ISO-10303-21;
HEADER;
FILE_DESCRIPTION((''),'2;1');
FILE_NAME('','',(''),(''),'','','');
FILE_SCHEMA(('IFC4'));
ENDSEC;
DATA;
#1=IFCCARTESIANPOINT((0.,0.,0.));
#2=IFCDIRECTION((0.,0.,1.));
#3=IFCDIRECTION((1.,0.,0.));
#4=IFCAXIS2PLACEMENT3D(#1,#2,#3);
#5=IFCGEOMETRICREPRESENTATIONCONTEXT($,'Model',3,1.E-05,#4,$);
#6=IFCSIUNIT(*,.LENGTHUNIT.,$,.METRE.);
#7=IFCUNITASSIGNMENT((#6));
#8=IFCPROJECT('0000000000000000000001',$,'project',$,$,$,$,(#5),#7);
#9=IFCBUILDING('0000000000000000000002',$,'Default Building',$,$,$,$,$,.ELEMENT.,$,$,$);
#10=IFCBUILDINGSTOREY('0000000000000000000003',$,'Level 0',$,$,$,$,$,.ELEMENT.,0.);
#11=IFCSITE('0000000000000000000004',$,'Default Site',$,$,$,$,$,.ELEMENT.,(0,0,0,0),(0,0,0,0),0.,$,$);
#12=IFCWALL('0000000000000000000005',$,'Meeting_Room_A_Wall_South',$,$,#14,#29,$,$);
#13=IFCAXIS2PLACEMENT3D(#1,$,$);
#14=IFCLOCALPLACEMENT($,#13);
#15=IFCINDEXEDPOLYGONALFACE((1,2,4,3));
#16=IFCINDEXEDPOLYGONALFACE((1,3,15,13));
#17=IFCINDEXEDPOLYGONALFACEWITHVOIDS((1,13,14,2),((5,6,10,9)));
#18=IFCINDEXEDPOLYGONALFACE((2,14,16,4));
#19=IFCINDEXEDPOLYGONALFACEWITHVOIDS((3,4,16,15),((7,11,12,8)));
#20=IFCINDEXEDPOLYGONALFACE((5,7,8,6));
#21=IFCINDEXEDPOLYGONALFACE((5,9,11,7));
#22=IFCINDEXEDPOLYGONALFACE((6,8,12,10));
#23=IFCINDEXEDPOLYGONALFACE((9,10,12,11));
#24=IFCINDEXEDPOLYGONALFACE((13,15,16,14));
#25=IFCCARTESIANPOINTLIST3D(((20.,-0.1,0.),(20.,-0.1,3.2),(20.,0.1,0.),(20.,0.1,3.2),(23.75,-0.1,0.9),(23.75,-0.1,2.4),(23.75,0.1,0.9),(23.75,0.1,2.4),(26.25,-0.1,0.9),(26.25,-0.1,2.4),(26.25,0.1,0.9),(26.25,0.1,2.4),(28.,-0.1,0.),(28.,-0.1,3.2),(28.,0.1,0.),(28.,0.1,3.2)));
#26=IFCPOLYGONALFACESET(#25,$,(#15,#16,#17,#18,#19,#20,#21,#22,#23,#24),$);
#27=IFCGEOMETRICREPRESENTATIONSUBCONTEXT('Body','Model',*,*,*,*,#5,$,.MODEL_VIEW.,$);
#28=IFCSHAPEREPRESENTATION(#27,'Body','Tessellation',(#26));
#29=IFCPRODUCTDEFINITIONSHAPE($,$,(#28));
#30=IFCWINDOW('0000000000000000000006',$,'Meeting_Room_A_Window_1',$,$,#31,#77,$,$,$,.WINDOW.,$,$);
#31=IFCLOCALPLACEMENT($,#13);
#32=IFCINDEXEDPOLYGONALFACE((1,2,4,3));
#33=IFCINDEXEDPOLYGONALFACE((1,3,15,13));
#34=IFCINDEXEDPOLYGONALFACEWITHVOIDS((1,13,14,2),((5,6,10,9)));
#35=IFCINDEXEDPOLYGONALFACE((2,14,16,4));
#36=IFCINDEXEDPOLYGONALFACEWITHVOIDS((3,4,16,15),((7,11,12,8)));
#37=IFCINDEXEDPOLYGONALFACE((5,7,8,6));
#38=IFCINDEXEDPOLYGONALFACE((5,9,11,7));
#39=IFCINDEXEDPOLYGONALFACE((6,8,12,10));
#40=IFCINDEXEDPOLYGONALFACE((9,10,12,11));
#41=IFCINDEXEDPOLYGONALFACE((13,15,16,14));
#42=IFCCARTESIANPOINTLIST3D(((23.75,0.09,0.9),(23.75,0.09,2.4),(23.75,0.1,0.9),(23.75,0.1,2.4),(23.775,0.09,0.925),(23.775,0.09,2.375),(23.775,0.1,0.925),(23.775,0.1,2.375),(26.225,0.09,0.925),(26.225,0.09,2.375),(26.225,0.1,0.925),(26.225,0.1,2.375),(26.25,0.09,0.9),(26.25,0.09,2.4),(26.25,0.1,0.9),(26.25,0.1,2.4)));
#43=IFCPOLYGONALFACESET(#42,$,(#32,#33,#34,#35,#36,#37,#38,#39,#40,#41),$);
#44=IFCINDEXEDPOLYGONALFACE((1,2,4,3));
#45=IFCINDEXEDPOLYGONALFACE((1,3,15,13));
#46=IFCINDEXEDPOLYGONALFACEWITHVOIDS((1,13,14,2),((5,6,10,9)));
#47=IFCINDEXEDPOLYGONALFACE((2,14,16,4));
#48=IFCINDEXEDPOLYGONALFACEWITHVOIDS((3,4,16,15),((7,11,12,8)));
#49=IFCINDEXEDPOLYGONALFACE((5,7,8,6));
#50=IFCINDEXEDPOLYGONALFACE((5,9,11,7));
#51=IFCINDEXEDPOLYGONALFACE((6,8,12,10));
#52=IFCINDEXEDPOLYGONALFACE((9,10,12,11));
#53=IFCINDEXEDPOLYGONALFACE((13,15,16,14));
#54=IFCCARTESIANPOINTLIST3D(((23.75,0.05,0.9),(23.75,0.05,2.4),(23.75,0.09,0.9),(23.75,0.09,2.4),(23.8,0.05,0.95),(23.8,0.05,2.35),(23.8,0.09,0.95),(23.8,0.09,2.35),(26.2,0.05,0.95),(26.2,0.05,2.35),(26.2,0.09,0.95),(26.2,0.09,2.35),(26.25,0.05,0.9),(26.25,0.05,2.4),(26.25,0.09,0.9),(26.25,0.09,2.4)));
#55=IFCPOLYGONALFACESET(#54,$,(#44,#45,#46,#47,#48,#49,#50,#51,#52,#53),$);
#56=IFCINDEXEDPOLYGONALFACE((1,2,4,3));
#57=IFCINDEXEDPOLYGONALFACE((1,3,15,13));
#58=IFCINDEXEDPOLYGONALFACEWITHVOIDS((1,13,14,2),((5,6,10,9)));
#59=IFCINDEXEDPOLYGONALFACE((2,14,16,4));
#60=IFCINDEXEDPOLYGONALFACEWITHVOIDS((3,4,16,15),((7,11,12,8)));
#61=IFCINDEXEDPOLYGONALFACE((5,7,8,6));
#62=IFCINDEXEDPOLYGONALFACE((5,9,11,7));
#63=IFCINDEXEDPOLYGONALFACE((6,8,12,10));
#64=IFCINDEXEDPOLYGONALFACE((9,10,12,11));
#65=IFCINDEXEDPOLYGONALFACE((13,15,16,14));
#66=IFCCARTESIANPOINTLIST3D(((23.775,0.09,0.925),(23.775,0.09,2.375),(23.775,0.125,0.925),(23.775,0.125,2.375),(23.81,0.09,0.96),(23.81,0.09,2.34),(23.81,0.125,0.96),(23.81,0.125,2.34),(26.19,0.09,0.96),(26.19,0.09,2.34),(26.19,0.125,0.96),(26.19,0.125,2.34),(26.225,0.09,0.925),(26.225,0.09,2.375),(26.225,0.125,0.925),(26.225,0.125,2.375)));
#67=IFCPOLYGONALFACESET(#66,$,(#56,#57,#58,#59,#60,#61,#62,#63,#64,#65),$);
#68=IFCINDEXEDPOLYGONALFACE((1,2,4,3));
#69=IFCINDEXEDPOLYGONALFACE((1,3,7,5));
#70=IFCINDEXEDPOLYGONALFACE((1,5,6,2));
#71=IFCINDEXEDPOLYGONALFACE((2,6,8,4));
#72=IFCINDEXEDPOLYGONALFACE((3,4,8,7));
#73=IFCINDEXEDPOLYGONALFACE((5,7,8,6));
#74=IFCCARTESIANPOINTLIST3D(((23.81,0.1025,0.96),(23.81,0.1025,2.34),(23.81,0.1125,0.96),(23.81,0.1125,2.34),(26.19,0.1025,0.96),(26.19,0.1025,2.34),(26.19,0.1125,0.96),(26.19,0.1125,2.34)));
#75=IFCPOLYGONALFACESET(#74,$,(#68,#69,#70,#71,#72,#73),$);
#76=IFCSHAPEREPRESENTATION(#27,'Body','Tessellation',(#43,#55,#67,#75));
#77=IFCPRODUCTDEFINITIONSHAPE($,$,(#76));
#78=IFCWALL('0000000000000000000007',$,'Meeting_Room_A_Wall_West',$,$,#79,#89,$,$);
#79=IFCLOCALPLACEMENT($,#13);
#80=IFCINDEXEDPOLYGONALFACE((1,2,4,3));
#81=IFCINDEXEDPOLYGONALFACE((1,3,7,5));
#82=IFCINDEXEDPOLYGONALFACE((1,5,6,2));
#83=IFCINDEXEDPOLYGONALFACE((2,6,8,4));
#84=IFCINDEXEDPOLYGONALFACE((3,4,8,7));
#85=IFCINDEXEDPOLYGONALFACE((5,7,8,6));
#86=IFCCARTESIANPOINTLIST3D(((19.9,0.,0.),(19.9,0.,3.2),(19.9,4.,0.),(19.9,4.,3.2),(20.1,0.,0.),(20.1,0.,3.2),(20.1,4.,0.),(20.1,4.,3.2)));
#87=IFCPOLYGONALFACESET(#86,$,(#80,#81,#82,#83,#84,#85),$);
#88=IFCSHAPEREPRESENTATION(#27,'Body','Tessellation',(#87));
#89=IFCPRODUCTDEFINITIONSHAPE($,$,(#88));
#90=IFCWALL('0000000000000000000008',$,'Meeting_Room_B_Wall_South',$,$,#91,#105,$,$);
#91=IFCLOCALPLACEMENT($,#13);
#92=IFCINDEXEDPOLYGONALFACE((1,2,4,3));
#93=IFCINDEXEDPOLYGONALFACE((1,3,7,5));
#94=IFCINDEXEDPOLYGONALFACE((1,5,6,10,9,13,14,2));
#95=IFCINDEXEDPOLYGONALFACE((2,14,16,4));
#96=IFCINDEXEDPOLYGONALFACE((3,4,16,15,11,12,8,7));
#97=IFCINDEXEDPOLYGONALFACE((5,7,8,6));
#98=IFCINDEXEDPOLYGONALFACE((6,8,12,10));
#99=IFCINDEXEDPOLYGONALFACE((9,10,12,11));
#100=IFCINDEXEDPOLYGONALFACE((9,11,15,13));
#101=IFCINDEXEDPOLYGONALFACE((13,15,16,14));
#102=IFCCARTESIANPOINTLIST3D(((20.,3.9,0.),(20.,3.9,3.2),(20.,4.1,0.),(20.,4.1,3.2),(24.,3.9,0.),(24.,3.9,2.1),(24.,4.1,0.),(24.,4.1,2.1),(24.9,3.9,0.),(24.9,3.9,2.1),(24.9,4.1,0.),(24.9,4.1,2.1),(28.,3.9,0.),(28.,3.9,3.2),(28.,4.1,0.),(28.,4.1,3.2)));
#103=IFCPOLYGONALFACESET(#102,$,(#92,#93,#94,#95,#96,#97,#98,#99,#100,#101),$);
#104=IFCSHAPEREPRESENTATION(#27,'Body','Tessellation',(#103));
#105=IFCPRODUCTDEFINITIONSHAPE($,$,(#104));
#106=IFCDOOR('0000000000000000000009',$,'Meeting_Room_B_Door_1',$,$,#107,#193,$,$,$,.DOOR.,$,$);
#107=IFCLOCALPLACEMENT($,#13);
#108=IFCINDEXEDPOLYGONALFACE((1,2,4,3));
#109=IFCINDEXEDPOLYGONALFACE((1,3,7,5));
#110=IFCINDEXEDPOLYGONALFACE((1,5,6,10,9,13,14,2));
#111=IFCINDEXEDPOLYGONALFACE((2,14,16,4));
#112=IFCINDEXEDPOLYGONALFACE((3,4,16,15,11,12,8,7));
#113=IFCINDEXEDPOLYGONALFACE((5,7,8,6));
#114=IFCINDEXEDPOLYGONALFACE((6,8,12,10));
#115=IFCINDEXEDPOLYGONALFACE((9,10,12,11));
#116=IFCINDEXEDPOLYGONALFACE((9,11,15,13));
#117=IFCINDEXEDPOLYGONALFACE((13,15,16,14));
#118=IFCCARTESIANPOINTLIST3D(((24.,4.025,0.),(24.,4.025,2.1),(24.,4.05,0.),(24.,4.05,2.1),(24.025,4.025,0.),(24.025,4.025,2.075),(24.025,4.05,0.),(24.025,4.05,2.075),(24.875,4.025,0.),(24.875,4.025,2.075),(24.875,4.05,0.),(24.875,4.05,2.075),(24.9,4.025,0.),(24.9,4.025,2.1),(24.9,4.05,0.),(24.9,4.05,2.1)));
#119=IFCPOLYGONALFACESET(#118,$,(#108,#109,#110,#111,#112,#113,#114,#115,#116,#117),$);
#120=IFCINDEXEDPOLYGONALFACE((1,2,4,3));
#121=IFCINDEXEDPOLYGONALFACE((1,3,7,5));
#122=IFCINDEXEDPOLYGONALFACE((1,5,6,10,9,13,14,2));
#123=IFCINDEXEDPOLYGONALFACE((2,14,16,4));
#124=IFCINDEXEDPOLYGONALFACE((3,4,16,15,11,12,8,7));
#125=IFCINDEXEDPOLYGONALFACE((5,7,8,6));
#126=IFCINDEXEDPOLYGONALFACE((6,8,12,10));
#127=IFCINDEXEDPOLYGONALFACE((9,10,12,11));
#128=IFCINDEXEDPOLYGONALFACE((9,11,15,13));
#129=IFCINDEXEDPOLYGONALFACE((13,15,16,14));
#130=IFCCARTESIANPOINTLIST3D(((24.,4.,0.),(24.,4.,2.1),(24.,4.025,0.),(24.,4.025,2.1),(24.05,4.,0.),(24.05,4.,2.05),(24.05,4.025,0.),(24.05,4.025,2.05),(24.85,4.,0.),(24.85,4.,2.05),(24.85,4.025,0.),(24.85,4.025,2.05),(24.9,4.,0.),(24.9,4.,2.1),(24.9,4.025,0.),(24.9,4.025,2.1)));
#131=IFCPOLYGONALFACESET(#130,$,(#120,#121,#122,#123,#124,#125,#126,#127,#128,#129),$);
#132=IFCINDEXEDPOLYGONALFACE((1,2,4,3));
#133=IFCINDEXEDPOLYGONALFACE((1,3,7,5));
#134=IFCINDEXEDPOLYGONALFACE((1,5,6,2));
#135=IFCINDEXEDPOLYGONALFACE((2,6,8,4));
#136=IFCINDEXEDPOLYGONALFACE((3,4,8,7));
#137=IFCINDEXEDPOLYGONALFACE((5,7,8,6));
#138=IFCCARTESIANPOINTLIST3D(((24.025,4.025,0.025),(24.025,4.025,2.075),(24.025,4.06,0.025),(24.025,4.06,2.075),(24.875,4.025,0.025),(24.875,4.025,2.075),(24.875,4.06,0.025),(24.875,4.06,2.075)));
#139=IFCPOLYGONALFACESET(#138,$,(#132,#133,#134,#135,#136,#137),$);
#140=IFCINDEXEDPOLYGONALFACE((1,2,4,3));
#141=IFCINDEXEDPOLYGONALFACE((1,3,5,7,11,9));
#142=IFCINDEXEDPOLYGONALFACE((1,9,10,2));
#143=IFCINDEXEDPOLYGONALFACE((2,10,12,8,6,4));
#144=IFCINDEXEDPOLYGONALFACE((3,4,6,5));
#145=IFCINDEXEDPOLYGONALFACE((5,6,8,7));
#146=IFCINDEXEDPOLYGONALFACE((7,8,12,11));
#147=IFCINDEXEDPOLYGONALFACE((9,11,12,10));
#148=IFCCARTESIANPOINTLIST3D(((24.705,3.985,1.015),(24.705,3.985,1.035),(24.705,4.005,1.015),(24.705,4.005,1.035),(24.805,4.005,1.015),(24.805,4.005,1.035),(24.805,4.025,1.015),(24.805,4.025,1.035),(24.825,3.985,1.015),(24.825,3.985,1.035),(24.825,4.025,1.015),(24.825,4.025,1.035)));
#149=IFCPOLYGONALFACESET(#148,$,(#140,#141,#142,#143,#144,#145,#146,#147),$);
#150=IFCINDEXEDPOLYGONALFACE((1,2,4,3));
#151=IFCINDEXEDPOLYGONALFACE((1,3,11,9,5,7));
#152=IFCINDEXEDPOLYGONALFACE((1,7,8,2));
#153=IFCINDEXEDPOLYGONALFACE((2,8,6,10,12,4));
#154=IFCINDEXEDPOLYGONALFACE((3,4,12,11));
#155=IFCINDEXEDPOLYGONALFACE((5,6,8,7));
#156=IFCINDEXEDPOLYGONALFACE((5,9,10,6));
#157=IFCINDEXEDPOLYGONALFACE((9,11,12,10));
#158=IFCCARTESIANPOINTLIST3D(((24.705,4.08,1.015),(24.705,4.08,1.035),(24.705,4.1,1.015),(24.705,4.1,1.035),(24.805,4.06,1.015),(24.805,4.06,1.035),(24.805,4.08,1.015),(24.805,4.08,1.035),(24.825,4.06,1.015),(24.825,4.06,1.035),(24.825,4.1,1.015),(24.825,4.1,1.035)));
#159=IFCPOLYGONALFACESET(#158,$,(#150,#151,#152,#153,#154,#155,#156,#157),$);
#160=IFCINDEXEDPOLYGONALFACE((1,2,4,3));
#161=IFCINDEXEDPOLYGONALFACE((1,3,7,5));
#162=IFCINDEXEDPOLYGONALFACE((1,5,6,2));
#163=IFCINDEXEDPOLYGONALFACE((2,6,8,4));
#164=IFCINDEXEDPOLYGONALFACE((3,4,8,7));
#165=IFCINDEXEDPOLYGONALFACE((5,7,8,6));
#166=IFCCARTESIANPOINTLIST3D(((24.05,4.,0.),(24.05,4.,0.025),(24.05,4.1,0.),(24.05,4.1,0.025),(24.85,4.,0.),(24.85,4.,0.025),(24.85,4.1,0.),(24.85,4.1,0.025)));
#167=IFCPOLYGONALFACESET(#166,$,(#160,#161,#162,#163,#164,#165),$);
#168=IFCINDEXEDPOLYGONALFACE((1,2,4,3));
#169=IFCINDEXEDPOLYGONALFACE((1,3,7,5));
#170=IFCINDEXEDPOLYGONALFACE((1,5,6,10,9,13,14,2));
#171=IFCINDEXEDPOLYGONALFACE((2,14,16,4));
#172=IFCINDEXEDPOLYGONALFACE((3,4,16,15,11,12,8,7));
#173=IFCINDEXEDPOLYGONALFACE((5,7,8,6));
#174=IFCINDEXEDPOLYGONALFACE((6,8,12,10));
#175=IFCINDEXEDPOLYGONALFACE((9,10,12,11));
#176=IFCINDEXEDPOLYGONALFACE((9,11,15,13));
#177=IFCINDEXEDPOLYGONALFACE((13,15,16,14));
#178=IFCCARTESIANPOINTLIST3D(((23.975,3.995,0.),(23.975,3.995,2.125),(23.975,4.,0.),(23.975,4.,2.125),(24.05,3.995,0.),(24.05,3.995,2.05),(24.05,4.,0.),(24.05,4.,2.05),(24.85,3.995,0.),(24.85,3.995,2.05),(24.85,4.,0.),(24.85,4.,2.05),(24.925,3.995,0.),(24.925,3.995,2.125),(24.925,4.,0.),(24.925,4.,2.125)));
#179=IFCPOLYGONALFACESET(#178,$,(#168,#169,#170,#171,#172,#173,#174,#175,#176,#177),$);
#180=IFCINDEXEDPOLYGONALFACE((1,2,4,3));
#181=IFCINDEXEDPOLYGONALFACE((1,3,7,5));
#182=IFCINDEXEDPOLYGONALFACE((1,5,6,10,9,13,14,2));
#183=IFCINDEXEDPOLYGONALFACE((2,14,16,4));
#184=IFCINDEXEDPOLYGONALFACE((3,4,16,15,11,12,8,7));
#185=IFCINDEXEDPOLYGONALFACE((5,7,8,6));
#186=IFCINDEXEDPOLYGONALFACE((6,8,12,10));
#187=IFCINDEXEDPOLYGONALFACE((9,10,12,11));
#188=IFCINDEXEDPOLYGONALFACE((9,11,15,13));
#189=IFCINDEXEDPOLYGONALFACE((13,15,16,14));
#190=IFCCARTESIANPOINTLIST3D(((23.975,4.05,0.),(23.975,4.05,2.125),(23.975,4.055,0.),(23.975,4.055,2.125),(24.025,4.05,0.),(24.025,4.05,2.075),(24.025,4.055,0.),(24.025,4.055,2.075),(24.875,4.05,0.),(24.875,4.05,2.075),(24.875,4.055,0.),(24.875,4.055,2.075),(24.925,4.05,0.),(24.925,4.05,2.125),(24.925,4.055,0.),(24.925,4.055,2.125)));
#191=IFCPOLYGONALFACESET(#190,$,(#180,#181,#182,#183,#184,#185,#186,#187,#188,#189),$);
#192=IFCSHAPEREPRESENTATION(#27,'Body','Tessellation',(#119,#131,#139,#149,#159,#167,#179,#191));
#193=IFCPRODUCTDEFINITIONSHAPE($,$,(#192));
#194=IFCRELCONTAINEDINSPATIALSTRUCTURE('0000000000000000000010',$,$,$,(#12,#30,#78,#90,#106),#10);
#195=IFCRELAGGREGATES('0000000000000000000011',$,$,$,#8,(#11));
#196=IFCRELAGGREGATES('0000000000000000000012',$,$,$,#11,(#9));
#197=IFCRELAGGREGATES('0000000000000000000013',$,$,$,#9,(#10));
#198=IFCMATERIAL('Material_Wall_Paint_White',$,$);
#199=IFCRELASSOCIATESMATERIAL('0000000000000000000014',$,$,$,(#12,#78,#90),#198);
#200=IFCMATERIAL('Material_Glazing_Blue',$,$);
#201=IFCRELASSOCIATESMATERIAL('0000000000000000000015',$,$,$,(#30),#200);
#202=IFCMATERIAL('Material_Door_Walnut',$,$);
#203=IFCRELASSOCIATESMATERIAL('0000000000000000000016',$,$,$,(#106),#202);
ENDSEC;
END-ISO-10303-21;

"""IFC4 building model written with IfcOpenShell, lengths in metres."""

from ifc_helpers import new_model, si_unit, frame, origin_with_axes, place, context, subcontext, project, spatial, line, indexed_curve, outline, extrude, material, element, fill, save


model = new_model("IFC4")

# Units and contexts
model_context = context("Model", 3, precision=1e-05, world=origin_with_axes())
body_context = subcontext(model_context, "Body", "Model", "MODEL_VIEW")
ifc_project = project(units=[si_unit("LENGTHUNIT", "METRE")], contexts=[model_context])

# Site, building, storey
site = spatial("IfcSite", under=ifc_project, Name="Default Site", CompositionType="ELEMENT", RefLatitude=(0, 0, 0, 0), RefLongitude=(0, 0, 0, 0), RefElevation=0.0)
building = spatial("IfcBuilding", under=site, Name="Default Building", CompositionType="ELEMENT")
storey = spatial("IfcBuildingStorey", under=building, Name="Level 0", CompositionType="ELEMENT", Elevation=0.0)

# Shared definitions
ifc_material_1 = material(Name="Material_Wall_Paint_White")

# Shared definitions
ifc_material_2 = material(Name="Material_Door_Walnut")

# Wall, opening, window
wall_1_placement = place(None, frame((20.0, 0.0, 0.0), z_axis=(0.0, 0.0, 1.0), x_axis=(1.0, 0.0, 0.0)))
wall_1 = element("IfcWall", 1, at=wall_1_placement, inside=storey, material=ifc_material_1, Name="Meeting_Room_A_Wall_South", context=body_context, shape_type="SweptSolid", body=[
    extrude(outline(indexed_curve([(0.0, 0.0), (0.0, 0.2), (8.0, 0.2), (8.0, 0.0), (0.0, 0.0)], self_intersect=False)), frame((0.0, -0.1, 0.0), z_axis=(0.0, 0.0, 1.0), x_axis=(1.0, 0.0, 0.0)), (0.0, 0.0, 1.0), 3.2),
])
opening_1_placement = place(wall_1_placement, frame((3.75, -0.5, 0.9), z_axis=(0.0, 0.0, 1.0), x_axis=(1.0, 0.0, 0.0)))
opening_1 = element("IfcOpeningElement", 2, at=opening_1_placement, inside=storey, cuts=wall_1, PredefinedType="OPENING", context=body_context, shape_type="SweptSolid", body=[
    extrude(outline(indexed_curve([(0.0, 0.0), (0.0, 1.0), (2.5, 1.0), (2.5, 0.0), (0.0, 0.0)], self_intersect=False)), origin_with_axes(), (0.0, 0.0, 1.0), 1.5),
])
ifc_material_3 = material(Name="Material_Glazing_Blue")
window_placement = place(None, frame((23.75, 0.0, 0.9), z_axis=(0.0, 0.0, 1.0), x_axis=(1.0, 0.0, 0.0)))
window = element("IfcWindow", 3, at=window_placement, inside=storey, material=ifc_material_3, Name="Meeting_Room_A_Window_1", PredefinedType="WINDOW", context=body_context, shape_type="SweptSolid", body=[
    extrude(outline(indexed_curve([(0.0, 0.0), (2.5, 0.0), (2.5, 1.5), (0.0, 1.5)], segments=[line(1, 2, 3, 4, 1)]), holes=[indexed_curve([(0.025, 0.025), (2.475, 0.025), (2.475, 1.475), (0.025, 1.475)], segments=[line(1, 2, 3, 4, 1)])]), frame((0.0, 0.09, 0.0), z_axis=(0.0, -1.0, 0.0), x_axis=(1.0, 0.0, 0.0)), (0.0, 0.0, -1.0), 0.01),
    extrude(outline(indexed_curve([(0.0, 0.0), (2.5, 0.0), (2.5, 1.5), (0.0, 1.5)], segments=[line(1, 2, 3, 4, 1)]), holes=[indexed_curve([(0.05, 0.05), (2.45, 0.05), (2.45, 1.45), (0.05, 1.45)], segments=[line(1, 2, 3, 4, 1)])]), frame((0.0, 0.05, 0.0), z_axis=(0.0, -1.0, 0.0), x_axis=(1.0, 0.0, 0.0)), (0.0, 0.0, -1.0), 0.04),
    extrude(outline(indexed_curve([(0.0, 0.0), (2.45, 0.0), (2.45, 1.45), (0.0, 1.45)], segments=[line(1, 2, 3, 4, 1)]), holes=[indexed_curve([(0.035, 0.035), (2.415, 0.035), (2.415, 1.415), (0.035, 1.415)], segments=[line(1, 2, 3, 4, 1)])]), frame((0.025, 0.09, 0.025), z_axis=(0.0, -1.0, 0.0), x_axis=(1.0, 0.0, 0.0)), (0.0, 0.0, -1.0), 0.035),
    extrude(outline(indexed_curve([(0.035, 0.035), (2.415, 0.035), (2.415, 1.415), (0.035, 1.415)], segments=[line(1, 2, 3, 4, 1)])), frame((0.025, 0.1025, 0.025), z_axis=(0.0, -1.0, 0.0), x_axis=(1.0, 0.0, 0.0)), (0.0, 0.0, -1.0), 0.01),
])
fill(opening_1, window)

# Wall
wall_2_placement = place(None, frame((20.0, 4.0, 0.0), z_axis=(0.0, 0.0, 1.0), x_axis=(0.0, -1.0, 0.0)))
element("IfcWall", 4, at=wall_2_placement, inside=storey, material=ifc_material_1, Name="Meeting_Room_A_Wall_West", context=body_context, shape_type="SweptSolid", body=[
    extrude(outline(indexed_curve([(0.0, 0.0), (0.0, 0.2), (4.0, 0.2), (4.0, 0.0), (0.0, 0.0)], self_intersect=False)), frame((0.0, -0.1, 0.0), z_axis=(0.0, 0.0, 1.0), x_axis=(1.0, 0.0, 0.0)), (0.0, 0.0, 1.0), 3.2),
])

# Wall, opening, door
wall_3_placement = place(None, frame((20.0, 4.0, 0.0), z_axis=(0.0, 0.0, 1.0), x_axis=(1.0, 0.0, 0.0)))
wall_3 = element("IfcWall", 5, at=wall_3_placement, inside=storey, material=ifc_material_1, Name="Meeting_Room_B_Wall_South", context=body_context, shape_type="SweptSolid", body=[
    extrude(outline(indexed_curve([(0.0, 0.0), (0.0, 0.2), (8.0, 0.2), (8.0, 0.0), (0.0, 0.0)], self_intersect=False)), frame((0.0, -0.1, 0.0), z_axis=(0.0, 0.0, 1.0), x_axis=(1.0, 0.0, 0.0)), (0.0, 0.0, 1.0), 3.2),
])
opening_2_placement = place(wall_3_placement, frame((4.0, -0.5, 0.0), z_axis=(0.0, 0.0, 1.0), x_axis=(1.0, 0.0, 0.0)))
opening_2 = element("IfcOpeningElement", 6, at=opening_2_placement, inside=storey, cuts=wall_3, PredefinedType="OPENING", context=body_context, shape_type="SweptSolid", body=[
    extrude(outline(indexed_curve([(0.0, 0.0), (0.0, 1.0), (0.9, 1.0), (0.9, 0.0), (0.0, 0.0)], self_intersect=False)), origin_with_axes(), (0.0, 0.0, 1.0), 2.1),
])
door_1_placement = place(None, frame((24.0, 4.0, 0.0), z_axis=(0.0, 0.0, 1.0), x_axis=(1.0, 0.0, 0.0)))
door_1 = element("IfcDoor", 7, at=door_1_placement, inside=storey, material=ifc_material_2, Name="Meeting_Room_B_Door_1", PredefinedType="DOOR", context=body_context, shape_type="SweptSolid", body=[
    extrude(outline(indexed_curve([(0.0, 0.0), (0.0, 2.1), (0.9, 2.1), (0.9, 0.0), (0.875, 0.0), (0.875, 2.075), (0.025, 2.075), (0.025, 0.0)], segments=[line(1, 2, 3, 4, 5, 6, 7, 8, 1)])), frame((0.0, 0.025, 0.0), z_axis=(0.0, -1.0, 0.0), x_axis=(1.0, 0.0, 0.0)), (0.0, 0.0, -1.0), 0.025),
    extrude(outline(indexed_curve([(0.0, 0.0), (0.0, 2.1), (0.9, 2.1), (0.9, 0.0), (0.85, 0.0), (0.85, 2.05), (0.05, 2.05), (0.05, 0.0)], segments=[line(1, 2, 3, 4, 5, 6, 7, 8, 1)])), frame((0.0, 0.0, 0.0), z_axis=(0.0, -1.0, 0.0), x_axis=(1.0, 0.0, 0.0)), (0.0, 0.0, -1.0), 0.025),
    extrude(outline(indexed_curve([(0.0, 0.0), (0.85, 0.0), (0.85, 0.035), (0.0, 0.035)], segments=[line(1, 2, 3, 4, 1)])), frame((0.025, 0.025, 0.025), z_axis=(0.0, 0.0, 1.0), x_axis=(1.0, 0.0, 0.0)), (0.0, 0.0, 1.0), 2.05),
    extrude(outline(indexed_curve([(0.0, 0.0), (0.0, -0.04), (-0.12, -0.04), (-0.12, -0.02), (-0.02, -0.02), (-0.02, 0.0)], segments=[line(1, 2, 3, 4, 5, 6, 1)])), frame((0.825, 0.025, 1.015), z_axis=(0.0, 0.0, 1.0), x_axis=(1.0, 0.0, 0.0)), (0.0, 0.0, 1.0), 0.02),
    extrude(outline(indexed_curve([(0.0, 0.0), (0.0, 0.04), (-0.12, 0.04), (-0.12, 0.02), (-0.02, 0.02), (-0.02, 0.0)], segments=[line(1, 2, 3, 4, 5, 6, 1)])), frame((0.825, 0.06, 1.015), z_axis=(0.0, 0.0, 1.0), x_axis=(1.0, 0.0, 0.0)), (0.0, 0.0, 1.0), 0.02),
    extrude(outline(indexed_curve([(0.0, 0.0), (0.8, 0.0), (0.8, 0.1), (0.0, 0.1)], segments=[line(1, 2, 3, 4, 1)])), frame((0.05, 0.0, 0.0), z_axis=(0.0, 0.0, 1.0), x_axis=(1.0, 0.0, 0.0)), (0.0, 0.0, 1.0), 0.025),
    extrude(outline(indexed_curve([(0.0, 0.0), (0.0, 2.125), (0.95, 2.125), (0.95, 0.0), (0.875, 0.0), (0.875, 2.05), (0.075, 2.05), (0.075, 0.0)], segments=[line(1, 2, 3, 4, 5, 6, 7, 8, 1)])), frame((-0.025, -0.005, 0.0), z_axis=(0.0, -1.0, 0.0), x_axis=(1.0, 0.0, 0.0)), (0.0, 0.0, -1.0), 0.005),
    extrude(outline(indexed_curve([(0.0, 0.0), (0.0, 2.125), (0.95, 2.125), (0.95, 0.0), (0.9, 0.0), (0.9, 2.075), (0.05, 2.075), (0.05, 0.0)], segments=[line(1, 2, 3, 4, 5, 6, 7, 8, 1)])), frame((-0.025, 0.05, 0.0), z_axis=(0.0, -1.0, 0.0), x_axis=(1.0, 0.0, 0.0)), (0.0, 0.0, -1.0), 0.005),
])
fill(opening_2, door_1)

save(model, "model.ifc")
